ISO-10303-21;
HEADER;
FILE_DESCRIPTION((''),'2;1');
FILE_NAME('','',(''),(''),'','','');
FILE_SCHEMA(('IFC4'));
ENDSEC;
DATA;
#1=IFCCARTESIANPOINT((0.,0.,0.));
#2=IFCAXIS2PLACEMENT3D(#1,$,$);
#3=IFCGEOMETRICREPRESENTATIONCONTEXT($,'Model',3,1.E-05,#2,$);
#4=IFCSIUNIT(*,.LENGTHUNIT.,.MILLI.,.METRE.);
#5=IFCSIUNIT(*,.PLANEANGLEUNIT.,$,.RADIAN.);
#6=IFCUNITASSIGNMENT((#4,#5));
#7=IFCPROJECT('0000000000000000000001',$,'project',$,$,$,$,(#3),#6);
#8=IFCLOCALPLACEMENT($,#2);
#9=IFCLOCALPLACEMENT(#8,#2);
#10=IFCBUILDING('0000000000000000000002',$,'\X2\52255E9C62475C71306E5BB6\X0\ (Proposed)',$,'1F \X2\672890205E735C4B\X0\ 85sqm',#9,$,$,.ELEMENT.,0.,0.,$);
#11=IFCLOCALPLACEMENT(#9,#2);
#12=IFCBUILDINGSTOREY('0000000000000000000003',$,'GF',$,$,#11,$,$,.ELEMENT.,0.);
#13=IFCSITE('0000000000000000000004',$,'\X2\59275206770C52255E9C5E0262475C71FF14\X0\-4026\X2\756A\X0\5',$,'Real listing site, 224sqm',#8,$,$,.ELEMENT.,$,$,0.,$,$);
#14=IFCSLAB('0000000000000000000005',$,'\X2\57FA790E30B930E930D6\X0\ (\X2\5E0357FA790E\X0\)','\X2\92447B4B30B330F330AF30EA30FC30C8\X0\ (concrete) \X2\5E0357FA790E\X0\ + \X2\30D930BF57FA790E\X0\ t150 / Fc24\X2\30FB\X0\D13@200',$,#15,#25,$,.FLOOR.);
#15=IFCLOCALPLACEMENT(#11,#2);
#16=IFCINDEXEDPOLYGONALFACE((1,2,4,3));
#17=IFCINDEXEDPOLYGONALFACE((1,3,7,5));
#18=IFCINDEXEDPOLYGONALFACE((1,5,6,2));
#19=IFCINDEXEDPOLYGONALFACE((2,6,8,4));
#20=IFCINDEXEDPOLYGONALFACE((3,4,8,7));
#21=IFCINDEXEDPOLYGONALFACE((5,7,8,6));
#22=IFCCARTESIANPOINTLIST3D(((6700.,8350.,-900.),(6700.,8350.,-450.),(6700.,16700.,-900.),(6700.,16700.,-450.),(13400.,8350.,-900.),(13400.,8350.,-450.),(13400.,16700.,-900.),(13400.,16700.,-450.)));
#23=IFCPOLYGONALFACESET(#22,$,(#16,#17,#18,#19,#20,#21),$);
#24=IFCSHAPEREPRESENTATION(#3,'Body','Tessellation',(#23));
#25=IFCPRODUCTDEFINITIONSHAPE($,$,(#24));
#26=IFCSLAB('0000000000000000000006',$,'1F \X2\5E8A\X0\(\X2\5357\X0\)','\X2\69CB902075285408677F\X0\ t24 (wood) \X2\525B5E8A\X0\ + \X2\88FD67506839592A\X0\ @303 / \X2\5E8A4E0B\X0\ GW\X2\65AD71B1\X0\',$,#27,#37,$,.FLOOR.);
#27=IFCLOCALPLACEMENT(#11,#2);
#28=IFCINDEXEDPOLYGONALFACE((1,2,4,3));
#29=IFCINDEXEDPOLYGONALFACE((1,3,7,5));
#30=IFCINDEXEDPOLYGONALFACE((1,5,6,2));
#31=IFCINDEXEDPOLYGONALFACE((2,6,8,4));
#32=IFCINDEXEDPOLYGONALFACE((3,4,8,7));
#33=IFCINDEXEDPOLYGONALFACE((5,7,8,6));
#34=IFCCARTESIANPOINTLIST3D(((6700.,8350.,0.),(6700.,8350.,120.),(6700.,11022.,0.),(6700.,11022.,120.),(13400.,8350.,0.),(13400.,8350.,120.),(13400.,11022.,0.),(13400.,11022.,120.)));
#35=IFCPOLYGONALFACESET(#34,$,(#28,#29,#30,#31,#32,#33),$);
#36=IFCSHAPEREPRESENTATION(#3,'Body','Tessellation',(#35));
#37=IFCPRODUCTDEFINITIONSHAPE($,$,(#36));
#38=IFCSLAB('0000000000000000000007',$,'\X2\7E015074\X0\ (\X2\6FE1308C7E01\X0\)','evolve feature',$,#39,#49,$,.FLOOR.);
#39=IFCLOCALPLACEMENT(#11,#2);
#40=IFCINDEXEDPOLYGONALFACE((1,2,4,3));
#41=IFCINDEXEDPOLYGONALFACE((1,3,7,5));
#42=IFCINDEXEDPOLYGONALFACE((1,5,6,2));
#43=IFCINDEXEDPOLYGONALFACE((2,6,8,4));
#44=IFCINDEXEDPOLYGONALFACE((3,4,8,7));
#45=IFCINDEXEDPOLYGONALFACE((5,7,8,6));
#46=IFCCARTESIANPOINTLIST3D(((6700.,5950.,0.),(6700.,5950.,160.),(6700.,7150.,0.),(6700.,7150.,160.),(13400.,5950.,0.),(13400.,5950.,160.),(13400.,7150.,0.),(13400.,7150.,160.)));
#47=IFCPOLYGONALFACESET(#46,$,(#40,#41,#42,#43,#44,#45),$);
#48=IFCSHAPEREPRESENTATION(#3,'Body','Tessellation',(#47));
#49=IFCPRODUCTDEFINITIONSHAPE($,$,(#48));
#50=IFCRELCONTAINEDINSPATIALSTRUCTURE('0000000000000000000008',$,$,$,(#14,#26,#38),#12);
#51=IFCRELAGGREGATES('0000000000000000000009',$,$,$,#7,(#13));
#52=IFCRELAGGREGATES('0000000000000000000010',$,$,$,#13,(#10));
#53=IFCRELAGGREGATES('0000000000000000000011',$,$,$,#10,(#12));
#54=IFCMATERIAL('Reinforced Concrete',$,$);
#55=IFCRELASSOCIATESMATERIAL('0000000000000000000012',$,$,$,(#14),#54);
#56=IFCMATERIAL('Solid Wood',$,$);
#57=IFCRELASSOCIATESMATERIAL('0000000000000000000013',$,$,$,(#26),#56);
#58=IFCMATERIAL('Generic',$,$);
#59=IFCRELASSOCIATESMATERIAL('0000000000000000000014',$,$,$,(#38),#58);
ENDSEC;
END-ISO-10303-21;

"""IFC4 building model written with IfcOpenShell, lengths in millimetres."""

from ifc_helpers import new_model, si_unit, frame, frame_2d, origin, place, context, project, spatial, rectangle, extrude, material, element, save


model = new_model("IFC4")

# Units and contexts
model_context = context("Model", 3, precision=1e-05, world=origin())
ifc_project = project(units=[si_unit("LENGTHUNIT", "METRE", prefix="MILLI"), si_unit("PLANEANGLEUNIT", "RADIAN")], contexts=[model_context])

# Site, building, storey
site_placement = place(None, origin())
site = spatial("IfcSite", under=ifc_project, at=site_placement, Name="大分県別府市扇山４-4026番5", ObjectType="Real listing site, 224sqm", CompositionType="ELEMENT", RefElevation=0.0)
building_placement = place(site_placement, origin())
building = spatial("IfcBuilding", under=site, at=building_placement, Name="別府扇山の家 (Proposed)", ObjectType="1F 木造平屋 85sqm", CompositionType="ELEMENT", ElevationOfRefHeight=0.0, ElevationOfTerrain=0.0)
storey_placement = place(building_placement, origin())
storey = spatial("IfcBuildingStorey", under=building, at=storey_placement, Name="GF", CompositionType="ELEMENT", Elevation=0.0)

# Slabs
ifc_material_1 = material(Name="Reinforced Concrete")
slab_1_placement = place(storey_placement, frame((3350.0, 4175.0, -450.0)))
element("IfcSlab", 1, at=slab_1_placement, inside=storey, material=ifc_material_1, Name="基礎スラブ (布基礎)", Description="鉄筋コンクリート (concrete) 布基礎 + ベタ基礎 t150 / Fc24・D13@200", PredefinedType="FLOOR", context=model_context, shape_type="SweptSolid", body=[
    extrude(rectangle(XDim=6700.0, YDim=8350.0, at=frame_2d((3350.0, 4175.0))), frame((3350.0, 4175.0, -450.0)), (0.0, 0.0, 1.0), 450.0),
])
ifc_material_2 = material(Name="Solid Wood")
slab_2_placement = place(storey_placement, frame((3350.0, 4175.0, 0.0)))
element("IfcSlab", 2, at=slab_2_placement, inside=storey, material=ifc_material_2, Name="1F 床(南)", Description="構造用合板 t24 (wood) 剛床 + 製材根太 @303 / 床下 GW断熱", PredefinedType="FLOOR", context=model_context, shape_type="SweptSolid", body=[
    extrude(rectangle(XDim=6700.0, YDim=2672.0, at=frame_2d((3350.0, 1336.0))), frame((3350.0, 4175.0, 0.0)), (0.0, 0.0, 1.0), 120.0),
])
ifc_material_3 = material(Name="Generic")
slab_3_placement = place(storey_placement, frame((3350.0, 2975.0, 0.0)))
element("IfcSlab", 3, at=slab_3_placement, inside=storey, material=ifc_material_3, Name="縁側 (濡れ縁)", Description="evolve feature", PredefinedType="FLOOR", context=model_context, shape_type="SweptSolid", body=[
    extrude(rectangle(XDim=6700.0, YDim=1200.0, at=frame_2d((3350.0, 600.0))), frame((3350.0, 2975.0, 0.0)), (0.0, 0.0, 1.0), 160.0),
])

save(model, "model.ifc")
